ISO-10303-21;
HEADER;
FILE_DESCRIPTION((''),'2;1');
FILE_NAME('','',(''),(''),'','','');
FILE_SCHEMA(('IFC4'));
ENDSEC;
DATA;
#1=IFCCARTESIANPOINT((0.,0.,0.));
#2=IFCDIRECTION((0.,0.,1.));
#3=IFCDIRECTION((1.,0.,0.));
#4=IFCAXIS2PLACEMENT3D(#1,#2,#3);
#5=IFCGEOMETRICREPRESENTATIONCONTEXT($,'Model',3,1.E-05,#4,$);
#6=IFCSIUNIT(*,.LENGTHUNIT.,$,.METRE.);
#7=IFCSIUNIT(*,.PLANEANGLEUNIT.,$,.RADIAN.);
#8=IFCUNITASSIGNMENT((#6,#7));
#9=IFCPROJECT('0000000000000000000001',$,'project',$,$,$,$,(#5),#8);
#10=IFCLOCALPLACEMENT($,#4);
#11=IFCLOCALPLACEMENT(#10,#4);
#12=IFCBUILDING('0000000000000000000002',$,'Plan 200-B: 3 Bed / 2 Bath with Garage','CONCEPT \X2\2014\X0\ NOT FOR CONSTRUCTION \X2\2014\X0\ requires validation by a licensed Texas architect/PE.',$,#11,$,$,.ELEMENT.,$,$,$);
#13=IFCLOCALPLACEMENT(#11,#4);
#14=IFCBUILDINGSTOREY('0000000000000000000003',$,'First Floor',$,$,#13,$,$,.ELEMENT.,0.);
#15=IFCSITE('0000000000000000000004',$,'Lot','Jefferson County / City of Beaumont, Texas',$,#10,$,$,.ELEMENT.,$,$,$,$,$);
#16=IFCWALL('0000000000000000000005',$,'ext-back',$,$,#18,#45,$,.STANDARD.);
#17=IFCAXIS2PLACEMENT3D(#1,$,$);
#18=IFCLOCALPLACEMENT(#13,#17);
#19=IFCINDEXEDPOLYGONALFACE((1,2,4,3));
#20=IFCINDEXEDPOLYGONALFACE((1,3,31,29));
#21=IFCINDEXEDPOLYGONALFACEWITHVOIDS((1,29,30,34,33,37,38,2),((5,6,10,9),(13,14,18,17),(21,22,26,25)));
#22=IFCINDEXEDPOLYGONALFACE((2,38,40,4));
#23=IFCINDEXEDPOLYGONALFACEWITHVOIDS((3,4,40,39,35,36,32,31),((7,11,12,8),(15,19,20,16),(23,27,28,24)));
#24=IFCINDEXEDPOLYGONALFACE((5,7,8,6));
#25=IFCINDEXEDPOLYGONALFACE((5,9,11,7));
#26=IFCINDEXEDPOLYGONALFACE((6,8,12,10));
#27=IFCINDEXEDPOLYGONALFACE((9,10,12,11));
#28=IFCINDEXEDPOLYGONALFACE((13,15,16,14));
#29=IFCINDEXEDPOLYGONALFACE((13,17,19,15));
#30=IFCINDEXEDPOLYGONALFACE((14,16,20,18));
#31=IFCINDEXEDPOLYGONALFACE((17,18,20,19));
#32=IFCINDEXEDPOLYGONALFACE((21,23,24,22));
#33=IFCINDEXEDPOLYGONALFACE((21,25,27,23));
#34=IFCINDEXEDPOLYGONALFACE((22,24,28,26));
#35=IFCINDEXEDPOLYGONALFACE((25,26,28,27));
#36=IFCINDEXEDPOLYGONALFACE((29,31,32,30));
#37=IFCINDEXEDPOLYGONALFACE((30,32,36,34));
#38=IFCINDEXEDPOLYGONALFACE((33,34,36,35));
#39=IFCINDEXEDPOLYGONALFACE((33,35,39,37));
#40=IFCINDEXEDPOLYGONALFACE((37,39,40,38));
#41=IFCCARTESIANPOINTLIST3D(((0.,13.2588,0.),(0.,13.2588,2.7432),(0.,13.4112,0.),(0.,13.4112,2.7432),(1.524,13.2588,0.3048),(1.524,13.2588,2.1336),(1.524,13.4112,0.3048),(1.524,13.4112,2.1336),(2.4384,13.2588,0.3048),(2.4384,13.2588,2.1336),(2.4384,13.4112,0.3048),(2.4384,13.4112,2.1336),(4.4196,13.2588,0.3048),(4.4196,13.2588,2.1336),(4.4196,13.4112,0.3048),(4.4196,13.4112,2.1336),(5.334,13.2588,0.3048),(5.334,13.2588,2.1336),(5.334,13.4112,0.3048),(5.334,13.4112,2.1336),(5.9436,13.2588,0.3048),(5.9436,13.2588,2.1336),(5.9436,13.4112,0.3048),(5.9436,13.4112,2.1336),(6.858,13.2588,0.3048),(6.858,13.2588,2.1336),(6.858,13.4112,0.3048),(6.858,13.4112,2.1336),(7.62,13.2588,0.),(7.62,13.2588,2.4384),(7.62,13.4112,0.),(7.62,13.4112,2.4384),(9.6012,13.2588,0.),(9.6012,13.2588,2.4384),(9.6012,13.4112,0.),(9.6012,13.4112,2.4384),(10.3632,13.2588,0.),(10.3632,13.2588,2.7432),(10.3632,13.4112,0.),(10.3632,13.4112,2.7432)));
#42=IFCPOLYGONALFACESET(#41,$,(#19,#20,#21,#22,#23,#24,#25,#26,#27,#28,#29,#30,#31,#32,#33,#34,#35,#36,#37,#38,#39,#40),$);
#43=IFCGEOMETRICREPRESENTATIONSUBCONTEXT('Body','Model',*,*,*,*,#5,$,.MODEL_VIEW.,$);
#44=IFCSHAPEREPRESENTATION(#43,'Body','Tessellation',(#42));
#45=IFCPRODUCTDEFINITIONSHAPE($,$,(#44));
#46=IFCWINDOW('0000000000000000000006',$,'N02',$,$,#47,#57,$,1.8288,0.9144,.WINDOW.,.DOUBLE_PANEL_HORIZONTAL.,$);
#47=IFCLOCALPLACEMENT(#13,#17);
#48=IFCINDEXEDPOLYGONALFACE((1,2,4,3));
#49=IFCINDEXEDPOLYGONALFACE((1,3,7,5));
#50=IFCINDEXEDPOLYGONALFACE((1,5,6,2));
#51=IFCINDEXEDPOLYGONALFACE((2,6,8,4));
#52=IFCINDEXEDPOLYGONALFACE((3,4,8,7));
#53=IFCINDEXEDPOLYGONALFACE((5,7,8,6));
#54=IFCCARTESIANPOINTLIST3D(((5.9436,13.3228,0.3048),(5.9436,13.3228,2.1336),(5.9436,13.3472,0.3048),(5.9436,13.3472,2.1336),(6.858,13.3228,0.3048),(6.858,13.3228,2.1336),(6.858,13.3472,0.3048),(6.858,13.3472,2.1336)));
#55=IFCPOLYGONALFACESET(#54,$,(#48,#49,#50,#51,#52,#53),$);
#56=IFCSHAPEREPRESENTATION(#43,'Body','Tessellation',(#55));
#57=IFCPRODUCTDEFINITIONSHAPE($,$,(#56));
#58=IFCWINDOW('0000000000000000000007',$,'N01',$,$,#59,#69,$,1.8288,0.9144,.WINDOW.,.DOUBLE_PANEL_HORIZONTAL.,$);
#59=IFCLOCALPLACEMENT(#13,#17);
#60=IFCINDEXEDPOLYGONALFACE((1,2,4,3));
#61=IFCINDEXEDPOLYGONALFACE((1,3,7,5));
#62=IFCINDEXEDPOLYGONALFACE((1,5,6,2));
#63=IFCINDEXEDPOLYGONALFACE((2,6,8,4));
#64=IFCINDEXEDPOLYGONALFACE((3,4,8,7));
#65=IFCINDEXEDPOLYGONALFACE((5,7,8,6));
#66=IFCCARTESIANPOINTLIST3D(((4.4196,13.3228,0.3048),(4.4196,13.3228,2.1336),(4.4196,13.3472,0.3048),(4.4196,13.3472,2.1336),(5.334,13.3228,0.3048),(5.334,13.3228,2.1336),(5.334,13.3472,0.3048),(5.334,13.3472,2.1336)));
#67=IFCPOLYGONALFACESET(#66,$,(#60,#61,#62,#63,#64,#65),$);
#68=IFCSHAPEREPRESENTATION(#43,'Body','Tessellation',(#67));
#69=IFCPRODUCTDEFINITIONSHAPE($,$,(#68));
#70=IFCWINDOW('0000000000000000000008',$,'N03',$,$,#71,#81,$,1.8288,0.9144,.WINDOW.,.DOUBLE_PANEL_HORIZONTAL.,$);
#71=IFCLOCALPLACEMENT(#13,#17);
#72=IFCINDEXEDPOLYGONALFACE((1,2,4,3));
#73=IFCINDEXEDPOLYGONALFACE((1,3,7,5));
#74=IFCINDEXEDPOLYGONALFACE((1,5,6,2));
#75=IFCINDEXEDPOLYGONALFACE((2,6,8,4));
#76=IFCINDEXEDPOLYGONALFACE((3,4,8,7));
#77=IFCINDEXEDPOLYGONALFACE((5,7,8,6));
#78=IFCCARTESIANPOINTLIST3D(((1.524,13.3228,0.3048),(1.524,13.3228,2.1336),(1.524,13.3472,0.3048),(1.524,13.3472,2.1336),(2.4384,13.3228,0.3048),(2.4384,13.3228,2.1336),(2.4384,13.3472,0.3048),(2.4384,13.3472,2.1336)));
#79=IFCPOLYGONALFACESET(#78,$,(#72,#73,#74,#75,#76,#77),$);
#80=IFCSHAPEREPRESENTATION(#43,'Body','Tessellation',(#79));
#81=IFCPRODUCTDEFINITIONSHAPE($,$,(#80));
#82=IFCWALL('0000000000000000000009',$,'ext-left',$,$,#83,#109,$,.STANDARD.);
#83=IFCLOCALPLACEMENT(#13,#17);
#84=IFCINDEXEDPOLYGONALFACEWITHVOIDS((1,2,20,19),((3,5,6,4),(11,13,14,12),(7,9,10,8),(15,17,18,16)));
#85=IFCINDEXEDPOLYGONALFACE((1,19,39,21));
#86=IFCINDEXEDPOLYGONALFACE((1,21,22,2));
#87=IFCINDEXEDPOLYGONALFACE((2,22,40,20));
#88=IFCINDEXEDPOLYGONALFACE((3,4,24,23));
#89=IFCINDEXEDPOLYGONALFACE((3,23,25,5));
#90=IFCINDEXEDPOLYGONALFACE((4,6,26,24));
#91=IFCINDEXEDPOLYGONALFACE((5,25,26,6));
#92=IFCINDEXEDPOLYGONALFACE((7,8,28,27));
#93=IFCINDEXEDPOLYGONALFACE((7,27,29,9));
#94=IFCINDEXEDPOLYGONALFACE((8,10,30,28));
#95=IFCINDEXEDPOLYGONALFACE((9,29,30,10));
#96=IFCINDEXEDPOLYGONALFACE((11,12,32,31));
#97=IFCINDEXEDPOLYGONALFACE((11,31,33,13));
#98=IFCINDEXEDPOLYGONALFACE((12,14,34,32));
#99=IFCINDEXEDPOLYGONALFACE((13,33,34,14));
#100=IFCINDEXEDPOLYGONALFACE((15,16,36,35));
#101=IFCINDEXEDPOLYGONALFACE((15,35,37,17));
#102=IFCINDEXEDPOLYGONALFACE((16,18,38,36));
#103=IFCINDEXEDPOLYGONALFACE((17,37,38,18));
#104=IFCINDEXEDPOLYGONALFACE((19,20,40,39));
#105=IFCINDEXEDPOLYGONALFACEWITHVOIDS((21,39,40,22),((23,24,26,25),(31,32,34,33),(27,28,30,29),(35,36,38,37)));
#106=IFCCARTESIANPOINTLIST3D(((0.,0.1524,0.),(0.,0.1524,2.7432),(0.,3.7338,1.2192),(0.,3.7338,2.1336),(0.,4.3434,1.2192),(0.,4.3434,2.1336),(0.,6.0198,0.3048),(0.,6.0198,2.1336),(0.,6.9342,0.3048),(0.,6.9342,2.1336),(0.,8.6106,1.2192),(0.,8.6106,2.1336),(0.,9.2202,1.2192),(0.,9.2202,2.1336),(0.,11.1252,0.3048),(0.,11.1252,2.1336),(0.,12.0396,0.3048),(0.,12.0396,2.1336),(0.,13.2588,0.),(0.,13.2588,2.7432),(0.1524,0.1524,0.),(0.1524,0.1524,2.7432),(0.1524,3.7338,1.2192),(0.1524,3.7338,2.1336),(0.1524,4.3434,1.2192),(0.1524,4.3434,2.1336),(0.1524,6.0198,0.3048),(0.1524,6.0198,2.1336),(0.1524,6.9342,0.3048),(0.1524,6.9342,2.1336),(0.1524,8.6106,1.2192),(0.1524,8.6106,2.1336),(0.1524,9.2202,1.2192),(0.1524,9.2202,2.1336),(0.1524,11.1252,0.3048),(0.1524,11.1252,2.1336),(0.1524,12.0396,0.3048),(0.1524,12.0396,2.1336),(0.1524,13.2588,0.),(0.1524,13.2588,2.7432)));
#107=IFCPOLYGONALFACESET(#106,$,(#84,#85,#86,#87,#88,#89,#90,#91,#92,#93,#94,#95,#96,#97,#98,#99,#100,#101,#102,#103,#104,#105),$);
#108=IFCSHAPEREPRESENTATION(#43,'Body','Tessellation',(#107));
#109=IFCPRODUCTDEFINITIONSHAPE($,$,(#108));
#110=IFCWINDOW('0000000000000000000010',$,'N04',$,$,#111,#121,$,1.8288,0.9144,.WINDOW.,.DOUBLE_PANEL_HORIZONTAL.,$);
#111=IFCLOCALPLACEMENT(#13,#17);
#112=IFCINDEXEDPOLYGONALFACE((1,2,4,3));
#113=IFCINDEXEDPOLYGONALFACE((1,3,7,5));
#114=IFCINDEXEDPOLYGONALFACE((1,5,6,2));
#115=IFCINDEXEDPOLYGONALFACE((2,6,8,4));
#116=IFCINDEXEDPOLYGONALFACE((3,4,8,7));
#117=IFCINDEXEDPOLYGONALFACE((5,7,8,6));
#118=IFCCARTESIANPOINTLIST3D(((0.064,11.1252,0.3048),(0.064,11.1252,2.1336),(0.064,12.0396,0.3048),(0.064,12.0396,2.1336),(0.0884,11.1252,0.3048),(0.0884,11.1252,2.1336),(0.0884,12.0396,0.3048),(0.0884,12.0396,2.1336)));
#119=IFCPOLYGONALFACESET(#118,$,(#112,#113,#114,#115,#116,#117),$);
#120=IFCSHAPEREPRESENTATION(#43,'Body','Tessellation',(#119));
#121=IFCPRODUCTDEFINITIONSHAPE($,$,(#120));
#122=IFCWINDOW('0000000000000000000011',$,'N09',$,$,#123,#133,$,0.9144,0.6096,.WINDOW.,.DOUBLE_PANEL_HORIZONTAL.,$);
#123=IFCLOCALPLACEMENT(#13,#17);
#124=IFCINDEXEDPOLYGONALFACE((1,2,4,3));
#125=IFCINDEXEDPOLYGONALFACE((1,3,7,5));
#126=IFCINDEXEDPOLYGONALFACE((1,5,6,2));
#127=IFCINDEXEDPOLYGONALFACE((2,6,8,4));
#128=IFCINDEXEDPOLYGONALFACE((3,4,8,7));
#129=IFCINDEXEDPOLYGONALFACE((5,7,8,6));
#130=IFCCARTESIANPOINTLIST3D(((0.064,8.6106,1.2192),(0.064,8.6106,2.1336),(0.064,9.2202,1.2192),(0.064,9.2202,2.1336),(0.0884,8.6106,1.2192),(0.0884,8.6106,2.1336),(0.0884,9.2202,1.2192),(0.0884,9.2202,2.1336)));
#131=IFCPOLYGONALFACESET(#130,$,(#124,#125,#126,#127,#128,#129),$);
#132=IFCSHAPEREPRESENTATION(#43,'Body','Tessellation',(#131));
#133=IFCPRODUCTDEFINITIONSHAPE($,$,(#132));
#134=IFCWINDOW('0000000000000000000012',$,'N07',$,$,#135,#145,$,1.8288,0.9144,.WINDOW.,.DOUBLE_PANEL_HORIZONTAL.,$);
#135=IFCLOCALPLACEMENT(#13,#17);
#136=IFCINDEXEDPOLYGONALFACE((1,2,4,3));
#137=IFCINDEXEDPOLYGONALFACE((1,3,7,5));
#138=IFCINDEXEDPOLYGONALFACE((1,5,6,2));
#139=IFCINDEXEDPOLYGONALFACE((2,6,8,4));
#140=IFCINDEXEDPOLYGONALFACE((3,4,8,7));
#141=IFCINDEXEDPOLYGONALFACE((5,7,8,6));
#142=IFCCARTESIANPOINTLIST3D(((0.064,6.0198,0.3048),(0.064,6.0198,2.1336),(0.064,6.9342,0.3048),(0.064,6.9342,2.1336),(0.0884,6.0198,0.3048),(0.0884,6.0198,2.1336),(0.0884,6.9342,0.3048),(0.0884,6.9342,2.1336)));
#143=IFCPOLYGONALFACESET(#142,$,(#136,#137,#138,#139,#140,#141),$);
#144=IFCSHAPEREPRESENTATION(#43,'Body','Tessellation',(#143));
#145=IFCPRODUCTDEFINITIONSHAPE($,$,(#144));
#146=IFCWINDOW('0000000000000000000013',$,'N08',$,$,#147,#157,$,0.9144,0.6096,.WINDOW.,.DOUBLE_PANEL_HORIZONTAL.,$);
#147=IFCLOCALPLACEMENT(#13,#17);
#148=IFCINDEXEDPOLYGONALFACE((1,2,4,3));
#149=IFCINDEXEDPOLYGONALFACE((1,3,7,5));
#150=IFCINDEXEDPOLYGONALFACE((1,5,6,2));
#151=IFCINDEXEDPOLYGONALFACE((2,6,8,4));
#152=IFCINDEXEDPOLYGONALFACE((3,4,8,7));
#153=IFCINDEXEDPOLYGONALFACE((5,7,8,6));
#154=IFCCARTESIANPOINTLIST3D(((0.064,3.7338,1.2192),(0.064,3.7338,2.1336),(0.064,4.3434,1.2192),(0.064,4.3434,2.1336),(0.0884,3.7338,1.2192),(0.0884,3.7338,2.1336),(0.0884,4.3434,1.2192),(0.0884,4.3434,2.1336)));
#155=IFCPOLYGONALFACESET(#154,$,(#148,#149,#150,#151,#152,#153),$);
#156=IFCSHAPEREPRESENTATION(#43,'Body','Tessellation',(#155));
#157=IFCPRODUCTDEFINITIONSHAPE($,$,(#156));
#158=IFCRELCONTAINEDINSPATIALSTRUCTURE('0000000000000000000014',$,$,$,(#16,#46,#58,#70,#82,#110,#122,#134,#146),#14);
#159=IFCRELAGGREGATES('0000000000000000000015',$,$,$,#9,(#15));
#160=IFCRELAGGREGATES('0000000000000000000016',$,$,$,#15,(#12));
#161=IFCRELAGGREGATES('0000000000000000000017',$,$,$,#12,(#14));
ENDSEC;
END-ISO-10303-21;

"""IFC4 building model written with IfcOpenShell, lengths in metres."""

from ifc_helpers import new_model, si_unit, frame, frame_2d, origin_with_axes, place, context, subcontext, project, spatial, rectangle, extrude, element, fill, save


model = new_model("IFC4")

# Units and contexts
model_context = context("Model", 3, precision=1e-05, world=origin_with_axes())
body_context = subcontext(model_context, "Body", "Model", "MODEL_VIEW")
ifc_project = project(units=[si_unit("LENGTHUNIT", "METRE"), si_unit("PLANEANGLEUNIT", "RADIAN")], contexts=[model_context])

# Site, building, storey
site_placement = place(None, origin_with_axes())
site = spatial("IfcSite", under=ifc_project, at=site_placement, Name="Lot", Description="Jefferson County / City of Beaumont, Texas", CompositionType="ELEMENT")
building_placement = place(site_placement, origin_with_axes())
building = spatial("IfcBuilding", under=site, at=building_placement, Name="Plan 200-B: 3 Bed / 2 Bath with Garage", Description="CONCEPT — NOT FOR CONSTRUCTION — requires validation by a licensed Texas architect/PE.", CompositionType="ELEMENT")
storey_placement = place(building_placement, origin_with_axes())
storey = spatial("IfcBuildingStorey", under=building, at=storey_placement, Name="First Floor", CompositionType="ELEMENT", Elevation=0.0)

# Walls, openings, windows
wall_1_placement = place(storey_placement, frame((10.3632, 13.335, 0.0), z_axis=(0.0, 0.0, 1.0), x_axis=(-1.0, 0.0, 0.0)))
wall_1 = element("IfcWall", 1, at=wall_1_placement, inside=storey, Name="ext-back", PredefinedType="STANDARD", context=body_context, shape_type="SweptSolid", body=[
    extrude(rectangle(XDim=10.3632, YDim=0.1524, at=frame_2d((5.1816, 0.0), x_axis=(1.0, 0.0))), origin_with_axes(), (0.0, 0.0, 1.0), 2.7432),
])
opening_1_placement = place(wall_1_placement, frame((0.762, 0.0, 0.0), z_axis=(0.0, 0.0, 1.0), x_axis=(1.0, 0.0, 0.0)))
element("IfcOpeningElement", 2, at=opening_1_placement, cuts=wall_1, PredefinedType="OPENING", context=body_context, shape_type="SweptSolid", body=[
    extrude(rectangle(XDim=1.9812, YDim=0.1829, at=frame_2d((0.9906, 0.0), x_axis=(1.0, 0.0))), origin_with_axes(), (0.0, 0.0, 1.0), 2.4384),
])
opening_2_placement = place(wall_1_placement, frame((3.5052, 0.0, 0.3048), z_axis=(0.0, 0.0, 1.0), x_axis=(1.0, 0.0, 0.0)))
opening_2 = element("IfcOpeningElement", 3, at=opening_2_placement, cuts=wall_1, PredefinedType="OPENING", context=body_context, shape_type="SweptSolid", body=[
    extrude(rectangle(XDim=0.9144, YDim=0.1829, at=frame_2d((0.4572, 0.0), x_axis=(1.0, 0.0))), origin_with_axes(), (0.0, 0.0, 1.0), 1.8288),
])
opening_3_placement = place(wall_1_placement, frame((5.0292, 0.0, 0.3048), z_axis=(0.0, 0.0, 1.0), x_axis=(1.0, 0.0, 0.0)))
opening_3 = element("IfcOpeningElement", 4, at=opening_3_placement, cuts=wall_1, PredefinedType="OPENING", context=body_context, shape_type="SweptSolid", body=[
    extrude(rectangle(XDim=0.9144, YDim=0.1829, at=frame_2d((0.4572, 0.0), x_axis=(1.0, 0.0))), origin_with_axes(), (0.0, 0.0, 1.0), 1.8288),
])
opening_4_placement = place(wall_1_placement, frame((7.9248, 0.0, 0.3048), z_axis=(0.0, 0.0, 1.0), x_axis=(1.0, 0.0, 0.0)))
opening_4 = element("IfcOpeningElement", 5, at=opening_4_placement, cuts=wall_1, PredefinedType="OPENING", context=body_context, shape_type="SweptSolid", body=[
    extrude(rectangle(XDim=0.9144, YDim=0.1829, at=frame_2d((0.4572, 0.0), x_axis=(1.0, 0.0))), origin_with_axes(), (0.0, 0.0, 1.0), 1.8288),
])
window_1_placement = place(opening_2_placement, origin_with_axes())
window_1 = element("IfcWindow", 6, at=window_1_placement, inside=storey, Name="N02", OverallHeight=1.8288, OverallWidth=0.9144, PartitioningType="DOUBLE_PANEL_HORIZONTAL", PredefinedType="WINDOW", context=body_context, shape_type="SweptSolid", body=[
    extrude(rectangle(XDim=0.9144, YDim=0.0244, at=frame_2d((0.4572, 0.0), x_axis=(1.0, 0.0))), origin_with_axes(), (0.0, 0.0, 1.0), 1.8288),
])
fill(opening_2, window_1)
window_2_placement = place(opening_3_placement, origin_with_axes())
window_2 = element("IfcWindow", 7, at=window_2_placement, inside=storey, Name="N01", OverallHeight=1.8288, OverallWidth=0.9144, PartitioningType="DOUBLE_PANEL_HORIZONTAL", PredefinedType="WINDOW", context=body_context, shape_type="SweptSolid", body=[
    extrude(rectangle(XDim=0.9144, YDim=0.0244, at=frame_2d((0.4572, 0.0), x_axis=(1.0, 0.0))), origin_with_axes(), (0.0, 0.0, 1.0), 1.8288),
])
fill(opening_3, window_2)
window_3_placement = place(opening_4_placement, origin_with_axes())
window_3 = element("IfcWindow", 8, at=window_3_placement, inside=storey, Name="N03", OverallHeight=1.8288, OverallWidth=0.9144, PartitioningType="DOUBLE_PANEL_HORIZONTAL", PredefinedType="WINDOW", context=body_context, shape_type="SweptSolid", body=[
    extrude(rectangle(XDim=0.9144, YDim=0.0244, at=frame_2d((0.4572, 0.0), x_axis=(1.0, 0.0))), origin_with_axes(), (0.0, 0.0, 1.0), 1.8288),
])
fill(opening_4, window_3)
wall_2_placement = place(storey_placement, frame((0.0762, 13.2588, 0.0), z_axis=(0.0, 0.0, 1.0), x_axis=(0.0, -1.0, 0.0)))
wall_2 = element("IfcWall", 9, at=wall_2_placement, inside=storey, Name="ext-left", PredefinedType="STANDARD", context=body_context, shape_type="SweptSolid", body=[
    extrude(rectangle(XDim=13.1064, YDim=0.1524, at=frame_2d((6.5532, 0.0), x_axis=(1.0, 0.0))), origin_with_axes(), (0.0, 0.0, 1.0), 2.7432),
])
opening_5_placement = place(wall_2_placement, frame((1.2192, 0.0, 0.3048), z_axis=(0.0, 0.0, 1.0), x_axis=(1.0, 0.0, 0.0)))
opening_5 = element("IfcOpeningElement", 10, at=opening_5_placement, cuts=wall_2, PredefinedType="OPENING", context=body_context, shape_type="SweptSolid", body=[
    extrude(rectangle(XDim=0.9144, YDim=0.1829, at=frame_2d((0.4572, 0.0), x_axis=(1.0, 0.0))), origin_with_axes(), (0.0, 0.0, 1.0), 1.8288),
])
opening_6_placement = place(wall_2_placement, frame((4.0386, 0.0, 1.2192), z_axis=(0.0, 0.0, 1.0), x_axis=(1.0, 0.0, 0.0)))
opening_6 = element("IfcOpeningElement", 11, at=opening_6_placement, cuts=wall_2, PredefinedType="OPENING", context=body_context, shape_type="SweptSolid", body=[
    extrude(rectangle(XDim=0.6096, YDim=0.1829, at=frame_2d((0.3048, 0.0), x_axis=(1.0, 0.0))), origin_with_axes(), (0.0, 0.0, 1.0), 0.9144),
])
opening_7_placement = place(wall_2_placement, frame((6.3246, 0.0, 0.3048), z_axis=(0.0, 0.0, 1.0), x_axis=(1.0, 0.0, 0.0)))
opening_7 = element("IfcOpeningElement", 12, at=opening_7_placement, cuts=wall_2, PredefinedType="OPENING", context=body_context, shape_type="SweptSolid", body=[
    extrude(rectangle(XDim=0.9144, YDim=0.1829, at=frame_2d((0.4572, 0.0), x_axis=(1.0, 0.0))), origin_with_axes(), (0.0, 0.0, 1.0), 1.8288),
])
opening_8_placement = place(wall_2_placement, frame((8.9154, 0.0, 1.2192), z_axis=(0.0, 0.0, 1.0), x_axis=(1.0, 0.0, 0.0)))
opening_8 = element("IfcOpeningElement", 13, at=opening_8_placement, cuts=wall_2, PredefinedType="OPENING", context=body_context, shape_type="SweptSolid", body=[
    extrude(rectangle(XDim=0.6096, YDim=0.1829, at=frame_2d((0.3048, 0.0), x_axis=(1.0, 0.0))), origin_with_axes(), (0.0, 0.0, 1.0), 0.9144),
])
window_4_placement = place(opening_5_placement, origin_with_axes())
window_4 = element("IfcWindow", 14, at=window_4_placement, inside=storey, Name="N04", OverallHeight=1.8288, OverallWidth=0.9144, PartitioningType="DOUBLE_PANEL_HORIZONTAL", PredefinedType="WINDOW", context=body_context, shape_type="SweptSolid", body=[
    extrude(rectangle(XDim=0.9144, YDim=0.0244, at=frame_2d((0.4572, 0.0), x_axis=(1.0, 0.0))), origin_with_axes(), (0.0, 0.0, 1.0), 1.8288),
])
fill(opening_5, window_4)
window_5_placement = place(opening_6_placement, origin_with_axes())
window_5 = element("IfcWindow", 15, at=window_5_placement, inside=storey, Name="N09", OverallHeight=0.9144, OverallWidth=0.6096, PartitioningType="DOUBLE_PANEL_HORIZONTAL", PredefinedType="WINDOW", context=body_context, shape_type="SweptSolid", body=[
    extrude(rectangle(XDim=0.6096, YDim=0.0244, at=frame_2d((0.3048, 0.0), x_axis=(1.0, 0.0))), origin_with_axes(), (0.0, 0.0, 1.0), 0.9144),
])
fill(opening_6, window_5)
window_6_placement = place(opening_7_placement, origin_with_axes())
window_6 = element("IfcWindow", 16, at=window_6_placement, inside=storey, Name="N07", OverallHeight=1.8288, OverallWidth=0.9144, PartitioningType="DOUBLE_PANEL_HORIZONTAL", PredefinedType="WINDOW", context=body_context, shape_type="SweptSolid", body=[
    extrude(rectangle(XDim=0.9144, YDim=0.0244, at=frame_2d((0.4572, 0.0), x_axis=(1.0, 0.0))), origin_with_axes(), (0.0, 0.0, 1.0), 1.8288),
])
fill(opening_7, window_6)
window_7_placement = place(opening_8_placement, origin_with_axes())
window_7 = element("IfcWindow", 17, at=window_7_placement, inside=storey, Name="N08", OverallHeight=0.9144, OverallWidth=0.6096, PartitioningType="DOUBLE_PANEL_HORIZONTAL", PredefinedType="WINDOW", context=body_context, shape_type="SweptSolid", body=[
    extrude(rectangle(XDim=0.6096, YDim=0.0244, at=frame_2d((0.3048, 0.0), x_axis=(1.0, 0.0))), origin_with_axes(), (0.0, 0.0, 1.0), 0.9144),
])
fill(opening_8, window_7)

save(model, "model.ifc")
